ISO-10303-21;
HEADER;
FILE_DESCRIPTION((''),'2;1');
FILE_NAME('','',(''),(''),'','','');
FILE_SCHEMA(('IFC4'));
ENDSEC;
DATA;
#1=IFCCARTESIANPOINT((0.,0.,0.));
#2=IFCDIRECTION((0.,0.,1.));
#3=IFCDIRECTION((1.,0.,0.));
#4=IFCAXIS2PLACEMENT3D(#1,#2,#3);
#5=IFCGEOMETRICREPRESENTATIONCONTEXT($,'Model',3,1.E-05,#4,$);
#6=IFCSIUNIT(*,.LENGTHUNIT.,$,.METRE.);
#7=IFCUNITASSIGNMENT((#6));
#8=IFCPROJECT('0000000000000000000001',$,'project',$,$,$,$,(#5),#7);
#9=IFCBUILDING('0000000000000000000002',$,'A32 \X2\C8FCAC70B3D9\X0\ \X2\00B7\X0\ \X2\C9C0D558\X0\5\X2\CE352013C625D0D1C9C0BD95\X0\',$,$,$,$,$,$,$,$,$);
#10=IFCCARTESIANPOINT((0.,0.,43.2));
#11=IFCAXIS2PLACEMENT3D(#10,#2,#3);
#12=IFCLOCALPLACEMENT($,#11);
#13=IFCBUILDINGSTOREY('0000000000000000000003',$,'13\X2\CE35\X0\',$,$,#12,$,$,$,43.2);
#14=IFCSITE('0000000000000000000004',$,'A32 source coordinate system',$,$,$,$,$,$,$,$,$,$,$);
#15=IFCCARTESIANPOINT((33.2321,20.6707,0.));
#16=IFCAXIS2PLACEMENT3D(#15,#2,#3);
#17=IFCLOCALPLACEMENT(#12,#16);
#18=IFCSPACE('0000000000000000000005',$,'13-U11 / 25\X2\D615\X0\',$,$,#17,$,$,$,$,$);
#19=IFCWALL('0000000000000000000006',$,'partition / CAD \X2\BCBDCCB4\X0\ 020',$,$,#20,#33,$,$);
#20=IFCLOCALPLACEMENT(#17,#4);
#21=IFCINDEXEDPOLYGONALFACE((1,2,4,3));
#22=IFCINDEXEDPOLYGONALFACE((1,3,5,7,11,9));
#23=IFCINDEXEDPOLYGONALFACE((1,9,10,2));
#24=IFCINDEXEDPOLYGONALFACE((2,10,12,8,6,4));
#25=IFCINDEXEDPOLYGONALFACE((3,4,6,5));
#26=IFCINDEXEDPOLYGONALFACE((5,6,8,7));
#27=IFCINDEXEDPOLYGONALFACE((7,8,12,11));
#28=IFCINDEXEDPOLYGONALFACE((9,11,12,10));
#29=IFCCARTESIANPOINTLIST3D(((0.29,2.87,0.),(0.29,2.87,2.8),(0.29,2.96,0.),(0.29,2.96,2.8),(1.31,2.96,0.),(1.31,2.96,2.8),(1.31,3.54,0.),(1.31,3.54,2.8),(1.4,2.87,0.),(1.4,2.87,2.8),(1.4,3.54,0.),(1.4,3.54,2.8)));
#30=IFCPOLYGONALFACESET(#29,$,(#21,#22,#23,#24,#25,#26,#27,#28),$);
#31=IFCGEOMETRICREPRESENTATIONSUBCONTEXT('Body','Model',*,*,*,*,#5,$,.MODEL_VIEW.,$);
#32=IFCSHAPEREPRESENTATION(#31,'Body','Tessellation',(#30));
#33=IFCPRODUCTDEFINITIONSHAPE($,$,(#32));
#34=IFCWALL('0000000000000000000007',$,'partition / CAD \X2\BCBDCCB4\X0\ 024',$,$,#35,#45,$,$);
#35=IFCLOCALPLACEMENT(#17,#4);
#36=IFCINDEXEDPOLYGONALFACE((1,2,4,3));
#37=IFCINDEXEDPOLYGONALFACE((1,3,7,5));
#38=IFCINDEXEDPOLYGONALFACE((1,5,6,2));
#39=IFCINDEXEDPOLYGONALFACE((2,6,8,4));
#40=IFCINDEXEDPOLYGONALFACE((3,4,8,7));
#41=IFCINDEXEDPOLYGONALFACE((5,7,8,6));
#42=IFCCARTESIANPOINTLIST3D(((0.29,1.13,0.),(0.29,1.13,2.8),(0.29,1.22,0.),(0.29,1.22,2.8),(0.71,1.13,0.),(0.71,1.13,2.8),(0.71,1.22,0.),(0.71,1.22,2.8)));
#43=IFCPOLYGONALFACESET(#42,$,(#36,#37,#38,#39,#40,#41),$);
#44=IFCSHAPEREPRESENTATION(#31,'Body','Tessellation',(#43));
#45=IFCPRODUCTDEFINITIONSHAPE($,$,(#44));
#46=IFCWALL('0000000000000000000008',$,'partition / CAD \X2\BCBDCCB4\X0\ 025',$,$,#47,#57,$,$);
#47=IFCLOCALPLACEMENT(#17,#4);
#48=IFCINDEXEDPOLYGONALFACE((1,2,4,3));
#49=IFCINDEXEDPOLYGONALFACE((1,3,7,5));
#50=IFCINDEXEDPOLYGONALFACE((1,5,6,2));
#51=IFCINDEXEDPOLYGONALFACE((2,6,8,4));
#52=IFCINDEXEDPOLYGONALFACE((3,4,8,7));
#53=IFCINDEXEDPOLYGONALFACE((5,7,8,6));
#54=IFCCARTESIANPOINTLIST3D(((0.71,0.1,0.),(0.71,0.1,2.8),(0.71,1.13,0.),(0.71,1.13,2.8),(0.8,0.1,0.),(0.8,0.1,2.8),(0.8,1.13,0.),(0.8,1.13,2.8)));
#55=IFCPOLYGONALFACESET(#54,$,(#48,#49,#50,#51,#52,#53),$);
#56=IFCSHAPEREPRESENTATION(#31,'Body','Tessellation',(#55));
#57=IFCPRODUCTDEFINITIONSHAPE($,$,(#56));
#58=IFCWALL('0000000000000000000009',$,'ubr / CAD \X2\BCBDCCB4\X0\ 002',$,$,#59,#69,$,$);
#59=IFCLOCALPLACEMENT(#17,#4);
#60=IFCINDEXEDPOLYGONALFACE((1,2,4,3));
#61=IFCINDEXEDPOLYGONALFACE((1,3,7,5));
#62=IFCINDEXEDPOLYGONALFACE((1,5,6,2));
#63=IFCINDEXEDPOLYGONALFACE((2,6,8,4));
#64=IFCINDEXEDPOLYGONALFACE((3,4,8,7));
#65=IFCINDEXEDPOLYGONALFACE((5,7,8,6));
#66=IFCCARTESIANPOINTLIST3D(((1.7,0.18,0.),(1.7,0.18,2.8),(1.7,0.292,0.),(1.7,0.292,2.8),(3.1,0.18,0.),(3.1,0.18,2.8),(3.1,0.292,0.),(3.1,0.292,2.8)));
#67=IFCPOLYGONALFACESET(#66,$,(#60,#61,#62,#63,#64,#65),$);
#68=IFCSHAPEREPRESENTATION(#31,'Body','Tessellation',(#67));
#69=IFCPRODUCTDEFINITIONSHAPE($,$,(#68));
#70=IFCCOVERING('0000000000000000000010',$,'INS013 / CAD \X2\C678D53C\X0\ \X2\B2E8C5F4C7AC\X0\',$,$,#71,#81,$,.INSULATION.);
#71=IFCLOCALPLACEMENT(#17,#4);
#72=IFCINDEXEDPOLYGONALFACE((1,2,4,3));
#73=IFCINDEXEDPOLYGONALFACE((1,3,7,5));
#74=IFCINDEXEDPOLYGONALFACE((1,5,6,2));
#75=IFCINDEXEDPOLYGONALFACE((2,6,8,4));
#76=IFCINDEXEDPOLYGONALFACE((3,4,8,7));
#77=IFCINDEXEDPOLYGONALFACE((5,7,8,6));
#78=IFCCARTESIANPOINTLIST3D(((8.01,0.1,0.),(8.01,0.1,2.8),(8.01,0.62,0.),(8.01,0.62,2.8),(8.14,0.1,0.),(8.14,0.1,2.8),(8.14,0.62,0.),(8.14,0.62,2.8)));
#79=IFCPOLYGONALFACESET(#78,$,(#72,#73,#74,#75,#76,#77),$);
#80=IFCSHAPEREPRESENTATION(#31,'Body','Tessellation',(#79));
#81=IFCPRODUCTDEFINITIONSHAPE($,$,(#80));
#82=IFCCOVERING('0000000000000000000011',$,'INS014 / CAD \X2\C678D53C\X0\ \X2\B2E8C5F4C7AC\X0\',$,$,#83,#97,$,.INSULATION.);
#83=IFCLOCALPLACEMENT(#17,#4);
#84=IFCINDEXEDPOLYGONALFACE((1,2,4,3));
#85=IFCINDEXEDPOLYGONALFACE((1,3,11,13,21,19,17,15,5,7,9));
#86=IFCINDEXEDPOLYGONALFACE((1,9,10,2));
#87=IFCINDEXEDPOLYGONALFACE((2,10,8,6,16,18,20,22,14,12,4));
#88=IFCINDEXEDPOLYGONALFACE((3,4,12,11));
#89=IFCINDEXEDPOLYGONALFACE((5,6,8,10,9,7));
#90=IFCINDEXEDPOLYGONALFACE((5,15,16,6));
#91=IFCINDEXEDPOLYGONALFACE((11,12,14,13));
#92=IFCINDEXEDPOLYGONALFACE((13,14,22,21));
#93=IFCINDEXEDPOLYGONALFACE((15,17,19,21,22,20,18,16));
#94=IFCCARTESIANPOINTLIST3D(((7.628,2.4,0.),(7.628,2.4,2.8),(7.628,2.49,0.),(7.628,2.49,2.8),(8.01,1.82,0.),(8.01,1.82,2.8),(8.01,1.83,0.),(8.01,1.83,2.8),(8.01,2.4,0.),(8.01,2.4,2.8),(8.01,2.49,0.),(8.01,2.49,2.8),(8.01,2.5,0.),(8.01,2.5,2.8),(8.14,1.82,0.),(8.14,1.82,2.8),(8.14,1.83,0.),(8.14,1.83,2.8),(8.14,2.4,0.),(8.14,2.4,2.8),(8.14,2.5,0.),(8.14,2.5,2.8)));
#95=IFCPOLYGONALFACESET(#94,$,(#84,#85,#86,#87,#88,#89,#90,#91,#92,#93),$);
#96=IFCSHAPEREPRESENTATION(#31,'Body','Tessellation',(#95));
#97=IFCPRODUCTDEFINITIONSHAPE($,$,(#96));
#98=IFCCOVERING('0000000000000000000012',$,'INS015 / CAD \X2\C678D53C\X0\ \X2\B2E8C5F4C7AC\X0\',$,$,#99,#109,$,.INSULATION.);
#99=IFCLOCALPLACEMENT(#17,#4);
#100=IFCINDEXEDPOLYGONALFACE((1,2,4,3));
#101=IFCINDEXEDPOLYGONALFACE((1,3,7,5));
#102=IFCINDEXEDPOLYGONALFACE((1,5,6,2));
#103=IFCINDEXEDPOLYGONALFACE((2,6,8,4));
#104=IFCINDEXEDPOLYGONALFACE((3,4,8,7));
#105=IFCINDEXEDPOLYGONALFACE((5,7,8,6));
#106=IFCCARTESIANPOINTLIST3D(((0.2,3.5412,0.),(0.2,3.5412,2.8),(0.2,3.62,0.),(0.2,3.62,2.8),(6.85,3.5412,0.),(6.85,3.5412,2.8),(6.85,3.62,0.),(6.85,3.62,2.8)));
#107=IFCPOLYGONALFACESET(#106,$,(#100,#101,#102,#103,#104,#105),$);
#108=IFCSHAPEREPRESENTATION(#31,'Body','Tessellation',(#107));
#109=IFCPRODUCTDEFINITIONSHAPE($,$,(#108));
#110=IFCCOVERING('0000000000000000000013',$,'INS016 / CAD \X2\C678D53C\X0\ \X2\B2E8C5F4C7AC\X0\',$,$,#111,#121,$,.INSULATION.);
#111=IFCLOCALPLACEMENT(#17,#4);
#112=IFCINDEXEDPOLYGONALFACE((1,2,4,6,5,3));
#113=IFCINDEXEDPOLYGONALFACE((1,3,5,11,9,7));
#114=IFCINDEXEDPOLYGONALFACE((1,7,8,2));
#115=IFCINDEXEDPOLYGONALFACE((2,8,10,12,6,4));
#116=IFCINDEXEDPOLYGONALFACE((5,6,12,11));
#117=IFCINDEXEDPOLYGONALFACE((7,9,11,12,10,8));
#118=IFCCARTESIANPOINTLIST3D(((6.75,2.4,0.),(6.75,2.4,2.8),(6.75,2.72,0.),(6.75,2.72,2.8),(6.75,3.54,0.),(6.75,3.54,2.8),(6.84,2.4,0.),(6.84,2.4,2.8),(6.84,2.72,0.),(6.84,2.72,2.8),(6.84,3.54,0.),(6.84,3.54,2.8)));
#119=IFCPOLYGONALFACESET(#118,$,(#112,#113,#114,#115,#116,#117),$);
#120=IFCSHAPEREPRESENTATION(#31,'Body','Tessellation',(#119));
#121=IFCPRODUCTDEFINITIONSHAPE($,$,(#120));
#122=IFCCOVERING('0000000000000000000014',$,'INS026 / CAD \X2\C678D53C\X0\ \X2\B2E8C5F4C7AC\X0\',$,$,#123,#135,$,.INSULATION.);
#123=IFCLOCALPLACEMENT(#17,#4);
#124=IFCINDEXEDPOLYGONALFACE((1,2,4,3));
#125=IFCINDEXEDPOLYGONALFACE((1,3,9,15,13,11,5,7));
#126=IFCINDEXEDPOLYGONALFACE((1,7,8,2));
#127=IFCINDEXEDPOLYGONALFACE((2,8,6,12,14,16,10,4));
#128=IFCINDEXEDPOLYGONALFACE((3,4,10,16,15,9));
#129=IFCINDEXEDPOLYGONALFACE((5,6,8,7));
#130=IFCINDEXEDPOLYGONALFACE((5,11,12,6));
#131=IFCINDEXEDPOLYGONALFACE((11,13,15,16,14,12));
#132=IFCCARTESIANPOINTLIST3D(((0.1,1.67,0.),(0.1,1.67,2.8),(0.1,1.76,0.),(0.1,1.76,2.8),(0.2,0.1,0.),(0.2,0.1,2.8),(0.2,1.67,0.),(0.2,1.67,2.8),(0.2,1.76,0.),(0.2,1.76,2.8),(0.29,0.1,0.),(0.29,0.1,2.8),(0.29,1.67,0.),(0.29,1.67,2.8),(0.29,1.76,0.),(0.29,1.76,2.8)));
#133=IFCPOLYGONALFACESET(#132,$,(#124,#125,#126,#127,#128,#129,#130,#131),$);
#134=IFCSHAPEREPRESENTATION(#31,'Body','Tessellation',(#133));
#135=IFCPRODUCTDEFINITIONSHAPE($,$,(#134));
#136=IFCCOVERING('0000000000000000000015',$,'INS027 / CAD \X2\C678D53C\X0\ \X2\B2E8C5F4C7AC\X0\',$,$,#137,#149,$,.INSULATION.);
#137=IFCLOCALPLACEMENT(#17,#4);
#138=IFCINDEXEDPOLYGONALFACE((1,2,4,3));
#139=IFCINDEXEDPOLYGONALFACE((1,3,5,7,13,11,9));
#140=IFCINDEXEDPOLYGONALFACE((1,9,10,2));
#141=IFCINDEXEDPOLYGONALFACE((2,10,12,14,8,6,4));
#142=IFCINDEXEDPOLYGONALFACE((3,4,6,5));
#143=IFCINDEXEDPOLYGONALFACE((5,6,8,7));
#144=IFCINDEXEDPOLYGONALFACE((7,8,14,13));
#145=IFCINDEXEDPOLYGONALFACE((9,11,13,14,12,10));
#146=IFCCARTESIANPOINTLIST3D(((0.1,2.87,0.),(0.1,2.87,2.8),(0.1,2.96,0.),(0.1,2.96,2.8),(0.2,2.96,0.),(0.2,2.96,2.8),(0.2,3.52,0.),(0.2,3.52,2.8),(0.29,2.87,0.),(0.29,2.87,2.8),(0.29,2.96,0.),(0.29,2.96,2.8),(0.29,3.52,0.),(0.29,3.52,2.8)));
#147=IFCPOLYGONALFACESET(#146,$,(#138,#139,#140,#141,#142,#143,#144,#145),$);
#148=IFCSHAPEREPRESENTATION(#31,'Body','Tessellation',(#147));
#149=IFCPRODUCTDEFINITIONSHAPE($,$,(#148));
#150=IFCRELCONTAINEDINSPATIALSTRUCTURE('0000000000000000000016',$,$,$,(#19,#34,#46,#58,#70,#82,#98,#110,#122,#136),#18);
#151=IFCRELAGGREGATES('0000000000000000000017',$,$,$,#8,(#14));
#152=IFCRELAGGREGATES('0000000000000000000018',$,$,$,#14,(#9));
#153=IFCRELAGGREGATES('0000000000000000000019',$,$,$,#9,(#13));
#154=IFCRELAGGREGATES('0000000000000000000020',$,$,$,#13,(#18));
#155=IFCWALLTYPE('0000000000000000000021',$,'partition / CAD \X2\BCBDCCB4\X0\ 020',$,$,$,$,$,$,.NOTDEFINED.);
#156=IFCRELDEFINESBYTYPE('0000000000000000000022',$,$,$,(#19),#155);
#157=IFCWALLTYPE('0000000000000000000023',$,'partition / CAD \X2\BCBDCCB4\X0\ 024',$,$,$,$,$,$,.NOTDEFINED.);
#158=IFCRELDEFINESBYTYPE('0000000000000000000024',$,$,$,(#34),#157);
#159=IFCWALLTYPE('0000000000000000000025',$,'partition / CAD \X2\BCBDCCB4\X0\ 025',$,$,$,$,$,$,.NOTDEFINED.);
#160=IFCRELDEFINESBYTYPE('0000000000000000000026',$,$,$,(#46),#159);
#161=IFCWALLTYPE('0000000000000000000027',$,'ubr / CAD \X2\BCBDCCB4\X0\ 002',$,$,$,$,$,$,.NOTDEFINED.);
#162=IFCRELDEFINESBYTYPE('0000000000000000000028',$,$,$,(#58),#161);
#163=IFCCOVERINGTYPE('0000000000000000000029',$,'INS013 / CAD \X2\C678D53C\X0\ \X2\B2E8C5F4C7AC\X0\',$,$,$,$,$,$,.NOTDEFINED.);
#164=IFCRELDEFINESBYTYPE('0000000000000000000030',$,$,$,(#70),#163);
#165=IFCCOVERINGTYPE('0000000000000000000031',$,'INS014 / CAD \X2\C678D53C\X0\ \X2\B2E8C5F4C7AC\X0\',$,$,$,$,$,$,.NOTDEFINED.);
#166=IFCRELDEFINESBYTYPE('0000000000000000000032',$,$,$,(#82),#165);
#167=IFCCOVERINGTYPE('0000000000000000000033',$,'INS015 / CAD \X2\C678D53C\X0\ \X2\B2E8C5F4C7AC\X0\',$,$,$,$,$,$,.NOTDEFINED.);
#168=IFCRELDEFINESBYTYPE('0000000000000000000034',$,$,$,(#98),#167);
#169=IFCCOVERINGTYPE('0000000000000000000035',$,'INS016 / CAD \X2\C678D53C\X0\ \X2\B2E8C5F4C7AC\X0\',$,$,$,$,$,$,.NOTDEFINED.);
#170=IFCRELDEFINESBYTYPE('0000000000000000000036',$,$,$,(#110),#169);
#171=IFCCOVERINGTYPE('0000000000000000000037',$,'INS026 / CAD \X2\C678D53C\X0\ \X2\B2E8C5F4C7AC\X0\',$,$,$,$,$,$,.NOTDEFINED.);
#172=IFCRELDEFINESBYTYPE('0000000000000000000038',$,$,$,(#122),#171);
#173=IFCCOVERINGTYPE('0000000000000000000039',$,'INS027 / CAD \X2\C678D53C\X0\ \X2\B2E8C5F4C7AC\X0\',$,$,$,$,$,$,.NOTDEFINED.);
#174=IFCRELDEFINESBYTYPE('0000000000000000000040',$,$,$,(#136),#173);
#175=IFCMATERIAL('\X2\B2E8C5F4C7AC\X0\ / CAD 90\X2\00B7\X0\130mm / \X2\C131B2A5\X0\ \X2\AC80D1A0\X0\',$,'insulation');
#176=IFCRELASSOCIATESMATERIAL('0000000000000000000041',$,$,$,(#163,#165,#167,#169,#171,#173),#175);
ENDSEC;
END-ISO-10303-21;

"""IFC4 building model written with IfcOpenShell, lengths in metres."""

from ifc_helpers import new_model, si_unit, frame, origin, origin_with_axes, place, context, subcontext, project, spatial, polyline, outline, extrude, source, transform, mapped, material, type_object, type_shapes, element, save


model = new_model("IFC4")

# Units and contexts
model_context = context("Model", 3, precision=1e-05, world=origin_with_axes())
body_context = subcontext(model_context, "Body", "Model", "MODEL_VIEW")
ifc_project = project(units=[si_unit("LENGTHUNIT", "METRE")], contexts=[model_context])

# Site, building, storey, space
storey_placement = place(None, frame((0.0, 0.0, 43.2), z_axis=(0.0, 0.0, 1.0), x_axis=(1.0, 0.0, 0.0)))
space_placement = place(storey_placement, frame((33.2321, 20.6707, 0.0), z_axis=(0.0, 0.0, 1.0), x_axis=(1.0, 0.0, 0.0)))
site = spatial("IfcSite", under=ifc_project, Name="A32 source coordinate system")
building = spatial("IfcBuilding", under=site, Name="A32 주거동 · 지하5층–옥탑지붕")
storey = spatial("IfcBuildingStorey", under=building, at=storey_placement, Name="13층", Elevation=43.2)
space = spatial("IfcSpace", under=storey, at=space_placement, Name="13-U11 / 25형")

# Walls
wall_type_1 = type_object("IfcWallType", Name="partition / CAD 벽체 020", PredefinedType="NOTDEFINED")
shared_shape_1 = source(origin(), body_context, "Body", "SweptSolid", [
    extrude(outline(polyline([(0.29, 2.87), (0.29, 2.96), (1.31, 2.96), (1.31, 3.54), (1.4, 3.54), (1.4, 2.87), (0.29, 2.87)])), origin(), (0.0, 0.0, 1.0), 2.8),
])
type_shapes(wall_type_1, [shared_shape_1])
wall_1_placement = place(space_placement, origin_with_axes())
element("IfcWall", 1, at=wall_1_placement, inside=space, type_object=wall_type_1, Name="partition / CAD 벽체 020", context=body_context, shape_type="MappedRepresentation", body=[
    mapped(shared_shape_1, transform((0.0, 0.0, 0.0), scale=1.0)),
])
wall_type_2 = type_object("IfcWallType", Name="partition / CAD 벽체 024", PredefinedType="NOTDEFINED")
shared_shape_2 = source(origin(), body_context, "Body", "SweptSolid", [
    extrude(outline(polyline([(0.71, 1.13), (0.29, 1.13), (0.29, 1.22), (0.71, 1.22), (0.71, 1.13)])), origin(), (0.0, 0.0, 1.0), 2.8),
])
type_shapes(wall_type_2, [shared_shape_2])
wall_2_placement = place(space_placement, origin_with_axes())
element("IfcWall", 2, at=wall_2_placement, inside=space, type_object=wall_type_2, Name="partition / CAD 벽체 024", context=body_context, shape_type="MappedRepresentation", body=[
    mapped(shared_shape_2, transform((0.0, 0.0, 0.0), scale=1.0)),
])
wall_type_3 = type_object("IfcWallType", Name="partition / CAD 벽체 025", PredefinedType="NOTDEFINED")
shared_shape_3 = source(origin(), body_context, "Body", "SweptSolid", [
    extrude(outline(polyline([(0.71, 1.13), (0.8, 1.13), (0.8, 0.1), (0.71, 0.1), (0.71, 1.13)])), origin(), (0.0, 0.0, 1.0), 2.8),
])
type_shapes(wall_type_3, [shared_shape_3])
wall_3_placement = place(space_placement, origin_with_axes())
element("IfcWall", 3, at=wall_3_placement, inside=space, type_object=wall_type_3, Name="partition / CAD 벽체 025", context=body_context, shape_type="MappedRepresentation", body=[
    mapped(shared_shape_3, transform((0.0, 0.0, 0.0), scale=1.0)),
])
wall_type_4 = type_object("IfcWallType", Name="ubr / CAD 벽체 002", PredefinedType="NOTDEFINED")
shared_shape_4 = source(origin(), body_context, "Body", "SweptSolid", [
    extrude(outline(polyline([(3.1, 0.292), (3.1, 0.18), (1.7, 0.18), (1.7, 0.292), (3.1, 0.292)])), origin(), (0.0, 0.0, 1.0), 2.8),
])
type_shapes(wall_type_4, [shared_shape_4])
wall_4_placement = place(space_placement, origin_with_axes())
element("IfcWall", 4, at=wall_4_placement, inside=space, type_object=wall_type_4, Name="ubr / CAD 벽체 002", context=body_context, shape_type="MappedRepresentation", body=[
    mapped(shared_shape_4, transform((0.0, 0.0, 0.0), scale=1.0)),
])

# Coverings
ifc_material = material(Name="단열재 / CAD 90·130mm / 성능 검토", Category="insulation")
covering_type_1 = type_object("IfcCoveringType", Name="INS013 / CAD 외피 단열재", PredefinedType="NOTDEFINED", material=ifc_material)
shared_shape_5 = source(origin(), body_context, "Body", "SweptSolid", [
    extrude(outline(polyline([(8.14, 0.1), (8.01, 0.1), (8.01, 0.62), (8.14, 0.62), (8.14, 0.1)])), origin(), (0.0, 0.0, 1.0), 2.8),
])
type_shapes(covering_type_1, [shared_shape_5])
covering_1_placement = place(space_placement, origin_with_axes())
element("IfcCovering", 5, at=covering_1_placement, inside=space, type_object=covering_type_1, Name="INS013 / CAD 외피 단열재", PredefinedType="INSULATION", context=body_context, shape_type="MappedRepresentation", body=[
    mapped(shared_shape_5, transform((0.0, 0.0, 0.0), scale=1.0)),
])
covering_type_2 = type_object("IfcCoveringType", Name="INS014 / CAD 외피 단열재", PredefinedType="NOTDEFINED", material=ifc_material)
shared_shape_6 = source(origin(), body_context, "Body", "SweptSolid", [
    extrude(outline(polyline([(8.14, 2.5), (8.14, 2.4), (8.14, 1.83), (8.14, 1.82), (8.01, 1.82), (8.01, 1.83), (8.01, 2.4), (7.628, 2.4), (7.628, 2.49), (8.01, 2.49), (8.01, 2.5), (8.14, 2.5)])), origin(), (0.0, 0.0, 1.0), 2.8),
])
type_shapes(covering_type_2, [shared_shape_6])
covering_2_placement = place(space_placement, origin_with_axes())
element("IfcCovering", 6, at=covering_2_placement, inside=space, type_object=covering_type_2, Name="INS014 / CAD 외피 단열재", PredefinedType="INSULATION", context=body_context, shape_type="MappedRepresentation", body=[
    mapped(shared_shape_6, transform((0.0, 0.0, 0.0), scale=1.0)),
])
covering_type_3 = type_object("IfcCoveringType", Name="INS015 / CAD 외피 단열재", PredefinedType="NOTDEFINED", material=ifc_material)
shared_shape_7 = source(origin(), body_context, "Body", "SweptSolid", [
    extrude(outline(polyline([(0.2, 3.5412), (0.2, 3.62), (6.85, 3.62), (6.85, 3.5412), (0.2, 3.5412)])), origin(), (0.0, 0.0, 1.0), 2.8),
])
type_shapes(covering_type_3, [shared_shape_7])
covering_3_placement = place(space_placement, origin_with_axes())
element("IfcCovering", 7, at=covering_3_placement, inside=space, type_object=covering_type_3, Name="INS015 / CAD 외피 단열재", PredefinedType="INSULATION", context=body_context, shape_type="MappedRepresentation", body=[
    mapped(shared_shape_7, transform((0.0, 0.0, 0.0), scale=1.0)),
])
covering_type_4 = type_object("IfcCoveringType", Name="INS016 / CAD 외피 단열재", PredefinedType="NOTDEFINED", material=ifc_material)
shared_shape_8 = source(origin(), body_context, "Body", "SweptSolid", [
    extrude(outline(polyline([(6.84, 2.72), (6.84, 2.4), (6.75, 2.4), (6.75, 2.72), (6.75, 3.54), (6.84, 3.54), (6.84, 2.72)])), origin(), (0.0, 0.0, 1.0), 2.8),
])
type_shapes(covering_type_4, [shared_shape_8])
covering_4_placement = place(space_placement, origin_with_axes())
element("IfcCovering", 8, at=covering_4_placement, inside=space, type_object=covering_type_4, Name="INS016 / CAD 외피 단열재", PredefinedType="INSULATION", context=body_context, shape_type="MappedRepresentation", body=[
    mapped(shared_shape_8, transform((0.0, 0.0, 0.0), scale=1.0)),
])
covering_type_5 = type_object("IfcCoveringType", Name="INS026 / CAD 외피 단열재", PredefinedType="NOTDEFINED", material=ifc_material)
shared_shape_9 = source(origin(), body_context, "Body", "SweptSolid", [
    extrude(outline(polyline([(0.2, 1.76), (0.29, 1.76), (0.29, 1.67), (0.29, 0.1), (0.2, 0.1), (0.2, 1.67), (0.1, 1.67), (0.1, 1.76), (0.2, 1.76)])), origin(), (0.0, 0.0, 1.0), 2.8),
])
type_shapes(covering_type_5, [shared_shape_9])
covering_5_placement = place(space_placement, origin_with_axes())
element("IfcCovering", 9, at=covering_5_placement, inside=space, type_object=covering_type_5, Name="INS026 / CAD 외피 단열재", PredefinedType="INSULATION", context=body_context, shape_type="MappedRepresentation", body=[
    mapped(shared_shape_9, transform((0.0, 0.0, 0.0), scale=1.0)),
])
covering_type_6 = type_object("IfcCoveringType", Name="INS027 / CAD 외피 단열재", PredefinedType="NOTDEFINED", material=ifc_material)
shared_shape_10 = source(origin(), body_context, "Body", "SweptSolid", [
    extrude(outline(polyline([(0.2, 3.52), (0.29, 3.52), (0.29, 2.96), (0.29, 2.87), (0.1, 2.87), (0.1, 2.96), (0.2, 2.96), (0.2, 3.52)])), origin(), (0.0, 0.0, 1.0), 2.8),
])
type_shapes(covering_type_6, [shared_shape_10])
covering_6_placement = place(space_placement, origin_with_axes())
element("IfcCovering", 10, at=covering_6_placement, inside=space, type_object=covering_type_6, Name="INS027 / CAD 외피 단열재", PredefinedType="INSULATION", context=body_context, shape_type="MappedRepresentation", body=[
    mapped(shared_shape_10, transform((0.0, 0.0, 0.0), scale=1.0)),
])

save(model, "model.ifc")
